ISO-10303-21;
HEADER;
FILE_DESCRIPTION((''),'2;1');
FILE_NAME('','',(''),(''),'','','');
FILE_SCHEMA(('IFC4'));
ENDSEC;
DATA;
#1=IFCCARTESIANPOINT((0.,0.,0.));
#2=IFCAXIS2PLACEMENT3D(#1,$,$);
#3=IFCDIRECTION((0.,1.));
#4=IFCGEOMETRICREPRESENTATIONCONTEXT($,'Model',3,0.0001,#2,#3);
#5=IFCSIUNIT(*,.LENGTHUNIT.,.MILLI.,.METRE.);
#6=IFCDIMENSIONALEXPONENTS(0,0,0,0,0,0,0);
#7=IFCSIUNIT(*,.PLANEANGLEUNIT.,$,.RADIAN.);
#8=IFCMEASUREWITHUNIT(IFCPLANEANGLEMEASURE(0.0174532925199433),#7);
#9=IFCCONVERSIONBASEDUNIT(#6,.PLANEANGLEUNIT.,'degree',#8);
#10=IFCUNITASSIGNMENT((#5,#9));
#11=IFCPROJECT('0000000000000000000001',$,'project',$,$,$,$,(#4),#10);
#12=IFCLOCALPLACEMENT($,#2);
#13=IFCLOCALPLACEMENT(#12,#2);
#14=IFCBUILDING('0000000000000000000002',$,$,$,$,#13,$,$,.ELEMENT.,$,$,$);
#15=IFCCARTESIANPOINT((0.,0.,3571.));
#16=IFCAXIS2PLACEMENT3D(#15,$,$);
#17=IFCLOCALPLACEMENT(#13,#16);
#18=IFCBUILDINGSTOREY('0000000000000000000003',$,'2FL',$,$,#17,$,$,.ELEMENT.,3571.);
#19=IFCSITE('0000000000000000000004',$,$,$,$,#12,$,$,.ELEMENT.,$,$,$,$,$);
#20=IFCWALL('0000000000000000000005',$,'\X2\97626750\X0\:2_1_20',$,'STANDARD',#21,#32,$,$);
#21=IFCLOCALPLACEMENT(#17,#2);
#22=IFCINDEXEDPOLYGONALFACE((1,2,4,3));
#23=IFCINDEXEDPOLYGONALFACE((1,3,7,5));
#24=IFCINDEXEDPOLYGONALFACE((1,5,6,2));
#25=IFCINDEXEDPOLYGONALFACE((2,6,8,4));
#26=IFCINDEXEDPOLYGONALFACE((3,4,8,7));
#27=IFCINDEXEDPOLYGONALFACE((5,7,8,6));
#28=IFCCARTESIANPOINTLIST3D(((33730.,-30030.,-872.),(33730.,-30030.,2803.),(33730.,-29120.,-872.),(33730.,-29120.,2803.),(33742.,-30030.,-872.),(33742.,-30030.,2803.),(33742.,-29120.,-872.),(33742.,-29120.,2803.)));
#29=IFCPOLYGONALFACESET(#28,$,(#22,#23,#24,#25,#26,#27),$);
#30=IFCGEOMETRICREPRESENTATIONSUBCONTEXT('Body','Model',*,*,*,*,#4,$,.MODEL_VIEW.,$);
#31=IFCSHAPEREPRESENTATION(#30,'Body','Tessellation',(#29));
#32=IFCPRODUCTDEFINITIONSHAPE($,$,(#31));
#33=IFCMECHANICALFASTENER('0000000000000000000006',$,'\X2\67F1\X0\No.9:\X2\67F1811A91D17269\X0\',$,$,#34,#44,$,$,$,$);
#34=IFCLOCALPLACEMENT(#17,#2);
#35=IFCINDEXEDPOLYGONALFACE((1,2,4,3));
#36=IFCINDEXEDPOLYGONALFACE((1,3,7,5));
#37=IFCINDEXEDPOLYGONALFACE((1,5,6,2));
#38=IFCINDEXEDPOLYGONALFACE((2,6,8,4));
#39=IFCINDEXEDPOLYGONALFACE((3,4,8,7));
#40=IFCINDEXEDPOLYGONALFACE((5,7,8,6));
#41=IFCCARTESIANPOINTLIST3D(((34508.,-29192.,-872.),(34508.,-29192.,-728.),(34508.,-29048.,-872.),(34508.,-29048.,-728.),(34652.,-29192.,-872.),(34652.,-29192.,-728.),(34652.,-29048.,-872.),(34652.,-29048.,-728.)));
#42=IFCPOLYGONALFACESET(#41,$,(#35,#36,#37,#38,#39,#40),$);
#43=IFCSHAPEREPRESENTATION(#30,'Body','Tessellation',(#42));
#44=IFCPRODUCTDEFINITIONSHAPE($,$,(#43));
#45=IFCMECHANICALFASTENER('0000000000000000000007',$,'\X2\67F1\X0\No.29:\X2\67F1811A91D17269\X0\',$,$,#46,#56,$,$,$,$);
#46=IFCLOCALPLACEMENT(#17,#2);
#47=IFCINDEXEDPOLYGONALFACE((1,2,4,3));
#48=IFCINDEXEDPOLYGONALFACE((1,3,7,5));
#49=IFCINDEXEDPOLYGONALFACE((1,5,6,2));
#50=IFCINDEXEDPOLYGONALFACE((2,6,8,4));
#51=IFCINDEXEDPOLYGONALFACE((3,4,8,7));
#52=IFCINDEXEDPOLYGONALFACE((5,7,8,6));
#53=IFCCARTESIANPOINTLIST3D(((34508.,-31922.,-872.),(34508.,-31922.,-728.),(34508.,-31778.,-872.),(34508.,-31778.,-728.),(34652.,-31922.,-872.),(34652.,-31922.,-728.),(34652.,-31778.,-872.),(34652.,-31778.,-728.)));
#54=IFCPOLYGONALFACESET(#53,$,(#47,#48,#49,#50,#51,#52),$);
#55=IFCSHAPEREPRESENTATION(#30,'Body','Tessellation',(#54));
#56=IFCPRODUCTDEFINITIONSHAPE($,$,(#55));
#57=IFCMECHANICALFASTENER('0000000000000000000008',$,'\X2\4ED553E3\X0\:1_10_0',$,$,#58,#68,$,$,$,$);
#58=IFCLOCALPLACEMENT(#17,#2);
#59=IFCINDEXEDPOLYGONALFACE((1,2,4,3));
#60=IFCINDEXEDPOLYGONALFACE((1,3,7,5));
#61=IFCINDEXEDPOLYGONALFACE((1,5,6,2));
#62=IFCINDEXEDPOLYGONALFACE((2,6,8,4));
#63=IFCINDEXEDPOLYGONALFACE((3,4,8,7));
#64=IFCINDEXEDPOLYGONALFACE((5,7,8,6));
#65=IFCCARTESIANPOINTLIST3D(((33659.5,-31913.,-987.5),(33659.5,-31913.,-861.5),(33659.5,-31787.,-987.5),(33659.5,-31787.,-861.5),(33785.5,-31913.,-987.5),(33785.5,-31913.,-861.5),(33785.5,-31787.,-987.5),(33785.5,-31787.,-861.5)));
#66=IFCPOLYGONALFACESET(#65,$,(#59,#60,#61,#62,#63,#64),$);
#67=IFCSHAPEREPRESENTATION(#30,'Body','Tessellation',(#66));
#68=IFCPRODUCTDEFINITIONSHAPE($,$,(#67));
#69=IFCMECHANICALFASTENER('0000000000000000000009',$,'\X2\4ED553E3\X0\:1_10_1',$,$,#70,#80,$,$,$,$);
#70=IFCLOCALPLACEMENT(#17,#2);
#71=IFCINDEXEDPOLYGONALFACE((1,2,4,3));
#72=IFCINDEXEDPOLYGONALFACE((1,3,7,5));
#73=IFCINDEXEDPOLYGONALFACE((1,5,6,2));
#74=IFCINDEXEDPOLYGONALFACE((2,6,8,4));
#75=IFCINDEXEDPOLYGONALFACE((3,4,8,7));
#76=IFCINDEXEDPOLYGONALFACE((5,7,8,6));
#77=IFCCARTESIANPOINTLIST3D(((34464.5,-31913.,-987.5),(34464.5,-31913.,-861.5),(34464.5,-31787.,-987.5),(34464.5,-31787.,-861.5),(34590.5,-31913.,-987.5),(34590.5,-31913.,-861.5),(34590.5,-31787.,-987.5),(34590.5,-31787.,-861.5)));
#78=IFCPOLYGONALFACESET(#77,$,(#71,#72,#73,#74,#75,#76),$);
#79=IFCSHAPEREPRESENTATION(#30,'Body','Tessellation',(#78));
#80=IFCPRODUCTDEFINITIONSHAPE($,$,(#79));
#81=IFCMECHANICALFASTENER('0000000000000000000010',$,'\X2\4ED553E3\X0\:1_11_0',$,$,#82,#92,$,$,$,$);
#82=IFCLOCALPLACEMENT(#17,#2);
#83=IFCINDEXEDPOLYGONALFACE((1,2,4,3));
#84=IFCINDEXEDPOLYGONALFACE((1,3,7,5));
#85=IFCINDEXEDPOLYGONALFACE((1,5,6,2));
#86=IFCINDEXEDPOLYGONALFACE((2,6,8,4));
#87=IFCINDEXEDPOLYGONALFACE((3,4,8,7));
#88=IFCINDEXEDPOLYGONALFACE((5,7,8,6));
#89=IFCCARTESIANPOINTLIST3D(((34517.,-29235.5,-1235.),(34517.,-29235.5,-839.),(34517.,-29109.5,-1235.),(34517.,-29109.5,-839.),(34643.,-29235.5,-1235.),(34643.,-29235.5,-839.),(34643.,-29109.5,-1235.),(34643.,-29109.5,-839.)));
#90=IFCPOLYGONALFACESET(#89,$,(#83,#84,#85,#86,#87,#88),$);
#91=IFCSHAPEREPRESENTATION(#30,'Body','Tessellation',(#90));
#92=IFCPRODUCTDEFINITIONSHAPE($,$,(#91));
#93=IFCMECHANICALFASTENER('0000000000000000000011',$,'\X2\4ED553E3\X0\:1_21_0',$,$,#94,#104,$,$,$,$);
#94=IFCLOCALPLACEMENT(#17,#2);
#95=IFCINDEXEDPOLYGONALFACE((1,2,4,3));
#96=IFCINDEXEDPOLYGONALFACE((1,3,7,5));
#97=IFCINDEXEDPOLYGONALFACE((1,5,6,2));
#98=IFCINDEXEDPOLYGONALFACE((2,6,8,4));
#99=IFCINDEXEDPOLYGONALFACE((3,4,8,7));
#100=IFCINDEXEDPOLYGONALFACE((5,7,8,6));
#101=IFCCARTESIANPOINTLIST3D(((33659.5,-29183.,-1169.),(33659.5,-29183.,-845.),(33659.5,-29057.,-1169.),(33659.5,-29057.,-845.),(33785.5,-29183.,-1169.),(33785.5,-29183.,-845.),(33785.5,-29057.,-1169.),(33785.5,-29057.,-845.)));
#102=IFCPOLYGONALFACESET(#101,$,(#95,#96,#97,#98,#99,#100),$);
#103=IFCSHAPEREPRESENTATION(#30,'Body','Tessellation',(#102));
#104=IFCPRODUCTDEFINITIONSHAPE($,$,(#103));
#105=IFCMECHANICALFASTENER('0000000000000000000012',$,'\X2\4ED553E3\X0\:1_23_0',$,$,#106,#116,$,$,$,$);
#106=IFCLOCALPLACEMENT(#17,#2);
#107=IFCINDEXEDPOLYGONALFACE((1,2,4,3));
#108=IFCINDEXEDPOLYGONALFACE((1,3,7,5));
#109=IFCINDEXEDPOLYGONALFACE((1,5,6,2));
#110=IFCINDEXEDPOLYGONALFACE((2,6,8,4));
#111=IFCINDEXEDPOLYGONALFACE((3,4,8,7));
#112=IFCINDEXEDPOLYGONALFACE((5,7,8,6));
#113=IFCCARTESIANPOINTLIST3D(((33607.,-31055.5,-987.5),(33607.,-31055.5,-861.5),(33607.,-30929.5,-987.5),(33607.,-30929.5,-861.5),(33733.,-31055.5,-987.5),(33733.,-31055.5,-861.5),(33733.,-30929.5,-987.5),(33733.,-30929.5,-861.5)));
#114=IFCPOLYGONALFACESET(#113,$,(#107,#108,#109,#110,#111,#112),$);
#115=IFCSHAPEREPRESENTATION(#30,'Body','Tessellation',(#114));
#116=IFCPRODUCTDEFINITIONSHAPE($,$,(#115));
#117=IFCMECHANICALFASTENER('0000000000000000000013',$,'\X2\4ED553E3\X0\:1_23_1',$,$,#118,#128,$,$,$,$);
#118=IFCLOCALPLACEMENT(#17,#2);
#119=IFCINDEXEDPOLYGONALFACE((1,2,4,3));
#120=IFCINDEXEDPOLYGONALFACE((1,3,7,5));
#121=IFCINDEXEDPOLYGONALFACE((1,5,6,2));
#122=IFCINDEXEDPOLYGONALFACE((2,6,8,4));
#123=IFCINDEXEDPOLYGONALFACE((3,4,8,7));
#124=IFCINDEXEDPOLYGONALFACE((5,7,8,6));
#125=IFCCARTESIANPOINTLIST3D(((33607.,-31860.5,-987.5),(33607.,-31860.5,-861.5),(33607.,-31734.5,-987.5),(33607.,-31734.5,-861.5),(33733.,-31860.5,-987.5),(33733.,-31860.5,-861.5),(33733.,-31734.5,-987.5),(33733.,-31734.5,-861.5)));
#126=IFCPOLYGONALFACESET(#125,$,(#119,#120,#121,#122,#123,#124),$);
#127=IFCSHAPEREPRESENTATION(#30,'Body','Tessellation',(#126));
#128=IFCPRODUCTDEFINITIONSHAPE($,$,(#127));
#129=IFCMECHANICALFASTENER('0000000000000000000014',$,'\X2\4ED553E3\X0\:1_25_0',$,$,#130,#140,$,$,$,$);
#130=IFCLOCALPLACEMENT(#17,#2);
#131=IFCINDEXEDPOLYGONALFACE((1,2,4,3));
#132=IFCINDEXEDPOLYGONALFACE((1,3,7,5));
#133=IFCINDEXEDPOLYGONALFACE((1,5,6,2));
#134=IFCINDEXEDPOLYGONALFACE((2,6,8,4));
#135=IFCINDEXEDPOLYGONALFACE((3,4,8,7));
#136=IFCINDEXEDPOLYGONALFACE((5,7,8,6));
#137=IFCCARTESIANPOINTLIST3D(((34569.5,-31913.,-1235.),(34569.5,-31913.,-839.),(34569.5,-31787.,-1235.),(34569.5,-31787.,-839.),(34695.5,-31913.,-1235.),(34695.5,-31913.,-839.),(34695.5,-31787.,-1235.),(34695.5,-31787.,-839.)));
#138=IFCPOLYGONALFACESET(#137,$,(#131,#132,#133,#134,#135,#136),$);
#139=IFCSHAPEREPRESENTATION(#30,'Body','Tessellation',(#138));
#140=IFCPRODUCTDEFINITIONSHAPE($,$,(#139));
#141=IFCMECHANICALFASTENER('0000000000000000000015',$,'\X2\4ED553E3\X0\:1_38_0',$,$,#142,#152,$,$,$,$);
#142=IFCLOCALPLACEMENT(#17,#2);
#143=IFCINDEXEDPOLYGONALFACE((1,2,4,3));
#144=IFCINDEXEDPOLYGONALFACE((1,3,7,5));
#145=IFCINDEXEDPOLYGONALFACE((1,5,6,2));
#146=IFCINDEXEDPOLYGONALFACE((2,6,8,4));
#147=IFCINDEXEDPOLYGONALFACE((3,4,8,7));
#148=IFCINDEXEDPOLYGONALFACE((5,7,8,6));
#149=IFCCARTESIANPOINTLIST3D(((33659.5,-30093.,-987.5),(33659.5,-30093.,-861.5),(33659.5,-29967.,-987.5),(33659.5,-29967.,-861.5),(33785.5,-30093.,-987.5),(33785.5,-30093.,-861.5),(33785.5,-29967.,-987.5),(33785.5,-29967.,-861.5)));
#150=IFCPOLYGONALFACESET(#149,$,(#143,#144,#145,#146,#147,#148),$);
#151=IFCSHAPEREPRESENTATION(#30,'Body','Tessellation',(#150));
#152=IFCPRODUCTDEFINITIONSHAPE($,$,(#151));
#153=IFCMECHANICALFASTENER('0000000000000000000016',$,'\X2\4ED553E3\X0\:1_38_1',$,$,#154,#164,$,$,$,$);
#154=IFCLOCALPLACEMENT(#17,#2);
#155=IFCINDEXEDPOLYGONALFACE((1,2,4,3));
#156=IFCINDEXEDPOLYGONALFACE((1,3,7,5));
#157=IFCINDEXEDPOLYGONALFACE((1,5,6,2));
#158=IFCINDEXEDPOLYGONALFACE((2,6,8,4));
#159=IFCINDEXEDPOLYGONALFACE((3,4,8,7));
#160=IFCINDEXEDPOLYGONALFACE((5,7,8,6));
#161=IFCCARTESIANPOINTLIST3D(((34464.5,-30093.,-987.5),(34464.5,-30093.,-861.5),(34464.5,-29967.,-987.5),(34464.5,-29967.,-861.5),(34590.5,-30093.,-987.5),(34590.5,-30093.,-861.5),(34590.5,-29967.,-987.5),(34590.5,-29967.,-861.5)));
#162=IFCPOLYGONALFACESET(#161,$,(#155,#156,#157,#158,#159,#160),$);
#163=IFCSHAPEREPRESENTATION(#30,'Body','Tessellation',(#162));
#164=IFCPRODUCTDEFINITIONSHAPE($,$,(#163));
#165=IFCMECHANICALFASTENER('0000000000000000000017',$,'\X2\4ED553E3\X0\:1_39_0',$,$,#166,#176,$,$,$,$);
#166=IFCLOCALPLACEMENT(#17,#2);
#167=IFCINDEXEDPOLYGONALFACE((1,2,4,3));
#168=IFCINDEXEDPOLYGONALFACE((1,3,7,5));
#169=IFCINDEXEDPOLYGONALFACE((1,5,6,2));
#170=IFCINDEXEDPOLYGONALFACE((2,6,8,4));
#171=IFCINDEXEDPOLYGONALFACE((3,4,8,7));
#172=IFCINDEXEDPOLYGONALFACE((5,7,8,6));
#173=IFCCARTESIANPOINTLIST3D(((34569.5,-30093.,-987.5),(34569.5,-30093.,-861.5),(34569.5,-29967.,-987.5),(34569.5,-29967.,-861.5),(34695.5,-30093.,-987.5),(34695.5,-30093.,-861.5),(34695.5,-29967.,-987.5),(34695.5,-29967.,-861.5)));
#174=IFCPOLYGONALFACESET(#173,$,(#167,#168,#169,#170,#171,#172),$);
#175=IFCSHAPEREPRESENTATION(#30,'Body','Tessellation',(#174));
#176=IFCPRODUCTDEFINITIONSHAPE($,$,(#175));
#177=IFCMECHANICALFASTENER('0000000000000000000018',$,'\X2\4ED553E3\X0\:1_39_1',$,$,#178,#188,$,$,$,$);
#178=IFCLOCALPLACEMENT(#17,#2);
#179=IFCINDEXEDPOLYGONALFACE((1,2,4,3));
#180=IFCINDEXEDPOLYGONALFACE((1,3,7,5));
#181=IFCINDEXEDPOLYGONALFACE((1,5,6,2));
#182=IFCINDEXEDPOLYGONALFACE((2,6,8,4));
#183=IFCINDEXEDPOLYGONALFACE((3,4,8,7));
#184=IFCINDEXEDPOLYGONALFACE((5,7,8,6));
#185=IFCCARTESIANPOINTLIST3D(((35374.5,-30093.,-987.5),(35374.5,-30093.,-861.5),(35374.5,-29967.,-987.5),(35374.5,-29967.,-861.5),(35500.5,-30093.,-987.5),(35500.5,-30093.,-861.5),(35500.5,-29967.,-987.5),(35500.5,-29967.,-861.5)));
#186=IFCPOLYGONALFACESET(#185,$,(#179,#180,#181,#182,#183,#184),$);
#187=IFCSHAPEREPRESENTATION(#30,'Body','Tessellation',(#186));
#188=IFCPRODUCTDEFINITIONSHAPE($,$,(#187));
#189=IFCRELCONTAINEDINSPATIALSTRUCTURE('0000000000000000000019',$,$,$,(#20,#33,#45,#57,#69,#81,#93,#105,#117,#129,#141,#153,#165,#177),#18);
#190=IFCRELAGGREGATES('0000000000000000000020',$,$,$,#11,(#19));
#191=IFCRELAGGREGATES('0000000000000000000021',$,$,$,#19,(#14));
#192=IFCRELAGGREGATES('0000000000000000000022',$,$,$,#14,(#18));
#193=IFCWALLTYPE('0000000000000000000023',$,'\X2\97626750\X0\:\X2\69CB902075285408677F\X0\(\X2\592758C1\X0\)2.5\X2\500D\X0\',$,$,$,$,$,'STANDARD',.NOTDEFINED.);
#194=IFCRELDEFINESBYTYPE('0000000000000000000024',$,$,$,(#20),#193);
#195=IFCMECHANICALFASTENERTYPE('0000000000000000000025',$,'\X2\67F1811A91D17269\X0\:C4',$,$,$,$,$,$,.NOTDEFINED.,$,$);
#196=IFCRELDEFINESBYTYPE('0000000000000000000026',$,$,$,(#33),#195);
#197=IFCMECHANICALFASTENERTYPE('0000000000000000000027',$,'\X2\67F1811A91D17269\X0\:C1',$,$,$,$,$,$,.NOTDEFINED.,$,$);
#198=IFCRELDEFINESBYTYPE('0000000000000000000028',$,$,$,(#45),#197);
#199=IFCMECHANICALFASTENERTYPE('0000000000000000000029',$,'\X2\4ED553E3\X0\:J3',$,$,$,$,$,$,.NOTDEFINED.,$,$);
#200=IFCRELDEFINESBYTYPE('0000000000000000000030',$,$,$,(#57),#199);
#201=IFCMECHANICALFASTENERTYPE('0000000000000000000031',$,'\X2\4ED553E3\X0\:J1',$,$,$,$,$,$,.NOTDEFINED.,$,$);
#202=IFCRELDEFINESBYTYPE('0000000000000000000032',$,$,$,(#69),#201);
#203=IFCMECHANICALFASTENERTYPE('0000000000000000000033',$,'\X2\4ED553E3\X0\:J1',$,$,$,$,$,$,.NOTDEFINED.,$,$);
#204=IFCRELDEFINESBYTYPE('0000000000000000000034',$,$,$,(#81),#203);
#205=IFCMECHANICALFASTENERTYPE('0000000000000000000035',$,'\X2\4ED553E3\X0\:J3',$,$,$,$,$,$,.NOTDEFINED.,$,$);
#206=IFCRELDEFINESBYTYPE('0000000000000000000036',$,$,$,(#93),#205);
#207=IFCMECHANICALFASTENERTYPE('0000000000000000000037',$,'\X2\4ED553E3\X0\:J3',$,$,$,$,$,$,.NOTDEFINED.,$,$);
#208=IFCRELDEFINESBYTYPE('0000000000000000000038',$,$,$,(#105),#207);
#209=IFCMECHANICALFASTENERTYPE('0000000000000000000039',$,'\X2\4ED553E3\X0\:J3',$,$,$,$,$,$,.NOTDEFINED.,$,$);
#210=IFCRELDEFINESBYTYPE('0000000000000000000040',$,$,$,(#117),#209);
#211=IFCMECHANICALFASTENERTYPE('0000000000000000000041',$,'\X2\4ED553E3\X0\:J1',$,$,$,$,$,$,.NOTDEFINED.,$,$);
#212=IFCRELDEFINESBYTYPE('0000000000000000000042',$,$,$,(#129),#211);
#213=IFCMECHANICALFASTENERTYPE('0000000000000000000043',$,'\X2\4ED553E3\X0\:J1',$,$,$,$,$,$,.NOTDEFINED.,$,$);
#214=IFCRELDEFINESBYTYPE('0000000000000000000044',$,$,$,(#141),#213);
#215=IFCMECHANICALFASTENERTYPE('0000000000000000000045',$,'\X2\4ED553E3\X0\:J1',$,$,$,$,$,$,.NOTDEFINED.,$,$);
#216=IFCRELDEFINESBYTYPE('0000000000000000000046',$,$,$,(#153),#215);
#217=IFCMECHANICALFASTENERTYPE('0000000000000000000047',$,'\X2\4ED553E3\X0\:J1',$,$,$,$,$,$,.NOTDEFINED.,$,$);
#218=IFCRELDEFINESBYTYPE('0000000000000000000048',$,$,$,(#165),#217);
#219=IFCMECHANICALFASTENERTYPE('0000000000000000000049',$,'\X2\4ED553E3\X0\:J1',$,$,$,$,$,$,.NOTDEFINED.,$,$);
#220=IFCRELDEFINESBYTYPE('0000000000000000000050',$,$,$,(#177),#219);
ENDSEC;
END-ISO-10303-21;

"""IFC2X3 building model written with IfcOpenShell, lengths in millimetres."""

from ifc_helpers import new_model, entity, si_unit, converted_unit, direction, frame, origin, origin_with_axes, origin_2d, place, context, subcontext, project, spatial, polyline, rectangle, outline, extrude, type_object, element, save


model = new_model("IFC2X3")

# Units and contexts
model_context = context("Model", 3, precision=0.0001, world=origin(), true_north=direction((0.0, 1.0)))
body_context = subcontext(model_context, "Body", "Model", "MODEL_VIEW")
ifc_project = project(units=[si_unit("LENGTHUNIT", "METRE", prefix="MILLI"), converted_unit("PLANEANGLEUNIT", "degree", entity("IfcPlaneAngleMeasure", 0.0174532925199433), si_unit("PLANEANGLEUNIT", "RADIAN"), dimensions=[0, 0, 0, 0, 0, 0, 0])], contexts=[model_context])

# Site, building, storey
site_placement = place(None, origin())
site = spatial("IfcSite", under=ifc_project, at=site_placement, CompositionType="ELEMENT")
building_placement = place(site_placement, origin())
building = spatial("IfcBuilding", under=site, at=building_placement, CompositionType="ELEMENT")
storey_placement = place(building_placement, frame((0.0, 0.0, 3571.0)))
storey = spatial("IfcBuildingStorey", under=building, at=storey_placement, Name="2FL", CompositionType="ELEMENT", Elevation=3571.0)

# Wall
wall_type = type_object("IfcWallType", Name="面材:構造用合板(大壁)2.5倍", ElementType="STANDARD", PredefinedType="NOTDEFINED")
wall_placement = place(storey_placement, frame((33742.0, -29575.0, -872.0), z_axis=(-1.0, 0.0, 0.0), x_axis=(0.0, -1.0, 0.0)))
element("IfcWall", 1, at=wall_placement, inside=storey, type_object=wall_type, Name="面材:2_1_20", ObjectType="STANDARD", context=body_context, shape_type="SweptSolid", body=[
    extrude(outline(polyline([(455.0, 0.0, 0.0), (-455.0, 0.0, 0.0), (-455.0, 3675.0, 0.0), (455.0, 3675.0, 0.0), (455.0, 0.0, 0.0)])), origin_with_axes(), (0.0, 0.0, 1.0), 12.0),
])

# Mechanical fasteners
mechanical_fastener_type_1 = type_object("IfcMechanicalFastenerType", Name="柱脚金物:C4")
mechanical_fastener_1_placement = place(storey_placement, frame((34580.0, -29120.0, -872.0)))
element("IfcMechanicalFastener", 2, at=mechanical_fastener_1_placement, inside=storey, type_object=mechanical_fastener_type_1, Name="柱No.9:柱脚金物", context=body_context, shape_type="SweptSolid", body=[
    extrude(rectangle(XDim=144.0, YDim=144.0, at=origin_2d()), origin_with_axes(), (0.0, 0.0, 1.0), 144.0),
])
mechanical_fastener_type_2 = type_object("IfcMechanicalFastenerType", Name="柱脚金物:C1")
mechanical_fastener_2_placement = place(storey_placement, frame((34580.0, -31850.0, -872.0)))
element("IfcMechanicalFastener", 3, at=mechanical_fastener_2_placement, inside=storey, type_object=mechanical_fastener_type_2, Name="柱No.29:柱脚金物", context=body_context, shape_type="SweptSolid", body=[
    extrude(rectangle(XDim=144.0, YDim=144.0, at=origin_2d()), origin_with_axes(), (0.0, 0.0, 1.0), 144.0),
])
mechanical_fastener_type_3 = type_object("IfcMechanicalFastenerType", Name="仕口:J3")
mechanical_fastener_3_placement = place(storey_placement, frame((33722.5, -31850.0, -987.5)))
element("IfcMechanicalFastener", 4, at=mechanical_fastener_3_placement, inside=storey, type_object=mechanical_fastener_type_3, Name="仕口:1_10_0", context=body_context, shape_type="SweptSolid", body=[
    extrude(rectangle(XDim=126.0, YDim=126.0, at=origin_2d()), origin_with_axes(), (0.0, 0.0, 1.0), 126.0),
])
mechanical_fastener_type_4 = type_object("IfcMechanicalFastenerType", Name="仕口:J1")
mechanical_fastener_4_placement = place(storey_placement, frame((34527.5, -31850.0, -987.5)))
element("IfcMechanicalFastener", 5, at=mechanical_fastener_4_placement, inside=storey, type_object=mechanical_fastener_type_4, Name="仕口:1_10_1", context=body_context, shape_type="SweptSolid", body=[
    extrude(rectangle(XDim=126.0, YDim=126.0, at=origin_2d()), origin_with_axes(), (0.0, 0.0, 1.0), 126.0),
])
mechanical_fastener_type_5 = type_object("IfcMechanicalFastenerType", Name="仕口:J1")
mechanical_fastener_5_placement = place(storey_placement, frame((34580.0, -29172.5, -1235.0)))
element("IfcMechanicalFastener", 6, at=mechanical_fastener_5_placement, inside=storey, type_object=mechanical_fastener_type_5, Name="仕口:1_11_0", context=body_context, shape_type="SweptSolid", body=[
    extrude(rectangle(XDim=126.0, YDim=126.0, at=origin_2d()), origin_with_axes(), (0.0, 0.0, 1.0), 396.0),
])
mechanical_fastener_type_6 = type_object("IfcMechanicalFastenerType", Name="仕口:J3")
mechanical_fastener_6_placement = place(storey_placement, frame((33722.5, -29120.0, -1169.0)))
element("IfcMechanicalFastener", 7, at=mechanical_fastener_6_placement, inside=storey, type_object=mechanical_fastener_type_6, Name="仕口:1_21_0", context=body_context, shape_type="SweptSolid", body=[
    extrude(rectangle(XDim=126.0, YDim=126.0, at=origin_2d()), origin_with_axes(), (0.0, 0.0, 1.0), 324.0),
])
mechanical_fastener_type_7 = type_object("IfcMechanicalFastenerType", Name="仕口:J3")
mechanical_fastener_7_placement = place(storey_placement, frame((33670.0, -30992.5, -987.5)))
element("IfcMechanicalFastener", 8, at=mechanical_fastener_7_placement, inside=storey, type_object=mechanical_fastener_type_7, Name="仕口:1_23_0", context=body_context, shape_type="SweptSolid", body=[
    extrude(rectangle(XDim=126.0, YDim=126.0, at=origin_2d()), origin_with_axes(), (0.0, 0.0, 1.0), 126.0),
])
mechanical_fastener_type_8 = type_object("IfcMechanicalFastenerType", Name="仕口:J3")
mechanical_fastener_8_placement = place(storey_placement, frame((33670.0, -31797.5, -987.5)))
element("IfcMechanicalFastener", 9, at=mechanical_fastener_8_placement, inside=storey, type_object=mechanical_fastener_type_8, Name="仕口:1_23_1", context=body_context, shape_type="SweptSolid", body=[
    extrude(rectangle(XDim=126.0, YDim=126.0, at=origin_2d()), origin_with_axes(), (0.0, 0.0, 1.0), 126.0),
])
mechanical_fastener_type_9 = type_object("IfcMechanicalFastenerType", Name="仕口:J1")
mechanical_fastener_9_placement = place(storey_placement, frame((34632.5, -31850.0, -1235.0)))
element("IfcMechanicalFastener", 10, at=mechanical_fastener_9_placement, inside=storey, type_object=mechanical_fastener_type_9, Name="仕口:1_25_0", context=body_context, shape_type="SweptSolid", body=[
    extrude(rectangle(XDim=126.0, YDim=126.0, at=origin_2d()), origin_with_axes(), (0.0, 0.0, 1.0), 396.0),
])
mechanical_fastener_type_10 = type_object("IfcMechanicalFastenerType", Name="仕口:J1")
mechanical_fastener_10_placement = place(storey_placement, frame((33722.5, -30030.0, -987.5)))
element("IfcMechanicalFastener", 11, at=mechanical_fastener_10_placement, inside=storey, type_object=mechanical_fastener_type_10, Name="仕口:1_38_0", context=body_context, shape_type="SweptSolid", body=[
    extrude(rectangle(XDim=126.0, YDim=126.0, at=origin_2d()), origin_with_axes(), (0.0, 0.0, 1.0), 126.0),
])
mechanical_fastener_type_11 = type_object("IfcMechanicalFastenerType", Name="仕口:J1")
mechanical_fastener_11_placement = place(storey_placement, frame((34527.5, -30030.0, -987.5)))
element("IfcMechanicalFastener", 12, at=mechanical_fastener_11_placement, inside=storey, type_object=mechanical_fastener_type_11, Name="仕口:1_38_1", context=body_context, shape_type="SweptSolid", body=[
    extrude(rectangle(XDim=126.0, YDim=126.0, at=origin_2d()), origin_with_axes(), (0.0, 0.0, 1.0), 126.0),
])
mechanical_fastener_type_12 = type_object("IfcMechanicalFastenerType", Name="仕口:J1")
mechanical_fastener_12_placement = place(storey_placement, frame((34632.5, -30030.0, -987.5)))
element("IfcMechanicalFastener", 13, at=mechanical_fastener_12_placement, inside=storey, type_object=mechanical_fastener_type_12, Name="仕口:1_39_0", context=body_context, shape_type="SweptSolid", body=[
    extrude(rectangle(XDim=126.0, YDim=126.0, at=origin_2d()), origin_with_axes(), (0.0, 0.0, 1.0), 126.0),
])
mechanical_fastener_type_13 = type_object("IfcMechanicalFastenerType", Name="仕口:J1")
mechanical_fastener_13_placement = place(storey_placement, frame((35437.5, -30030.0, -987.5)))
element("IfcMechanicalFastener", 14, at=mechanical_fastener_13_placement, inside=storey, type_object=mechanical_fastener_type_13, Name="仕口:1_39_1", context=body_context, shape_type="SweptSolid", body=[
    extrude(rectangle(XDim=126.0, YDim=126.0, at=origin_2d()), origin_with_axes(), (0.0, 0.0, 1.0), 126.0),
])

save(model, "model.ifc")
